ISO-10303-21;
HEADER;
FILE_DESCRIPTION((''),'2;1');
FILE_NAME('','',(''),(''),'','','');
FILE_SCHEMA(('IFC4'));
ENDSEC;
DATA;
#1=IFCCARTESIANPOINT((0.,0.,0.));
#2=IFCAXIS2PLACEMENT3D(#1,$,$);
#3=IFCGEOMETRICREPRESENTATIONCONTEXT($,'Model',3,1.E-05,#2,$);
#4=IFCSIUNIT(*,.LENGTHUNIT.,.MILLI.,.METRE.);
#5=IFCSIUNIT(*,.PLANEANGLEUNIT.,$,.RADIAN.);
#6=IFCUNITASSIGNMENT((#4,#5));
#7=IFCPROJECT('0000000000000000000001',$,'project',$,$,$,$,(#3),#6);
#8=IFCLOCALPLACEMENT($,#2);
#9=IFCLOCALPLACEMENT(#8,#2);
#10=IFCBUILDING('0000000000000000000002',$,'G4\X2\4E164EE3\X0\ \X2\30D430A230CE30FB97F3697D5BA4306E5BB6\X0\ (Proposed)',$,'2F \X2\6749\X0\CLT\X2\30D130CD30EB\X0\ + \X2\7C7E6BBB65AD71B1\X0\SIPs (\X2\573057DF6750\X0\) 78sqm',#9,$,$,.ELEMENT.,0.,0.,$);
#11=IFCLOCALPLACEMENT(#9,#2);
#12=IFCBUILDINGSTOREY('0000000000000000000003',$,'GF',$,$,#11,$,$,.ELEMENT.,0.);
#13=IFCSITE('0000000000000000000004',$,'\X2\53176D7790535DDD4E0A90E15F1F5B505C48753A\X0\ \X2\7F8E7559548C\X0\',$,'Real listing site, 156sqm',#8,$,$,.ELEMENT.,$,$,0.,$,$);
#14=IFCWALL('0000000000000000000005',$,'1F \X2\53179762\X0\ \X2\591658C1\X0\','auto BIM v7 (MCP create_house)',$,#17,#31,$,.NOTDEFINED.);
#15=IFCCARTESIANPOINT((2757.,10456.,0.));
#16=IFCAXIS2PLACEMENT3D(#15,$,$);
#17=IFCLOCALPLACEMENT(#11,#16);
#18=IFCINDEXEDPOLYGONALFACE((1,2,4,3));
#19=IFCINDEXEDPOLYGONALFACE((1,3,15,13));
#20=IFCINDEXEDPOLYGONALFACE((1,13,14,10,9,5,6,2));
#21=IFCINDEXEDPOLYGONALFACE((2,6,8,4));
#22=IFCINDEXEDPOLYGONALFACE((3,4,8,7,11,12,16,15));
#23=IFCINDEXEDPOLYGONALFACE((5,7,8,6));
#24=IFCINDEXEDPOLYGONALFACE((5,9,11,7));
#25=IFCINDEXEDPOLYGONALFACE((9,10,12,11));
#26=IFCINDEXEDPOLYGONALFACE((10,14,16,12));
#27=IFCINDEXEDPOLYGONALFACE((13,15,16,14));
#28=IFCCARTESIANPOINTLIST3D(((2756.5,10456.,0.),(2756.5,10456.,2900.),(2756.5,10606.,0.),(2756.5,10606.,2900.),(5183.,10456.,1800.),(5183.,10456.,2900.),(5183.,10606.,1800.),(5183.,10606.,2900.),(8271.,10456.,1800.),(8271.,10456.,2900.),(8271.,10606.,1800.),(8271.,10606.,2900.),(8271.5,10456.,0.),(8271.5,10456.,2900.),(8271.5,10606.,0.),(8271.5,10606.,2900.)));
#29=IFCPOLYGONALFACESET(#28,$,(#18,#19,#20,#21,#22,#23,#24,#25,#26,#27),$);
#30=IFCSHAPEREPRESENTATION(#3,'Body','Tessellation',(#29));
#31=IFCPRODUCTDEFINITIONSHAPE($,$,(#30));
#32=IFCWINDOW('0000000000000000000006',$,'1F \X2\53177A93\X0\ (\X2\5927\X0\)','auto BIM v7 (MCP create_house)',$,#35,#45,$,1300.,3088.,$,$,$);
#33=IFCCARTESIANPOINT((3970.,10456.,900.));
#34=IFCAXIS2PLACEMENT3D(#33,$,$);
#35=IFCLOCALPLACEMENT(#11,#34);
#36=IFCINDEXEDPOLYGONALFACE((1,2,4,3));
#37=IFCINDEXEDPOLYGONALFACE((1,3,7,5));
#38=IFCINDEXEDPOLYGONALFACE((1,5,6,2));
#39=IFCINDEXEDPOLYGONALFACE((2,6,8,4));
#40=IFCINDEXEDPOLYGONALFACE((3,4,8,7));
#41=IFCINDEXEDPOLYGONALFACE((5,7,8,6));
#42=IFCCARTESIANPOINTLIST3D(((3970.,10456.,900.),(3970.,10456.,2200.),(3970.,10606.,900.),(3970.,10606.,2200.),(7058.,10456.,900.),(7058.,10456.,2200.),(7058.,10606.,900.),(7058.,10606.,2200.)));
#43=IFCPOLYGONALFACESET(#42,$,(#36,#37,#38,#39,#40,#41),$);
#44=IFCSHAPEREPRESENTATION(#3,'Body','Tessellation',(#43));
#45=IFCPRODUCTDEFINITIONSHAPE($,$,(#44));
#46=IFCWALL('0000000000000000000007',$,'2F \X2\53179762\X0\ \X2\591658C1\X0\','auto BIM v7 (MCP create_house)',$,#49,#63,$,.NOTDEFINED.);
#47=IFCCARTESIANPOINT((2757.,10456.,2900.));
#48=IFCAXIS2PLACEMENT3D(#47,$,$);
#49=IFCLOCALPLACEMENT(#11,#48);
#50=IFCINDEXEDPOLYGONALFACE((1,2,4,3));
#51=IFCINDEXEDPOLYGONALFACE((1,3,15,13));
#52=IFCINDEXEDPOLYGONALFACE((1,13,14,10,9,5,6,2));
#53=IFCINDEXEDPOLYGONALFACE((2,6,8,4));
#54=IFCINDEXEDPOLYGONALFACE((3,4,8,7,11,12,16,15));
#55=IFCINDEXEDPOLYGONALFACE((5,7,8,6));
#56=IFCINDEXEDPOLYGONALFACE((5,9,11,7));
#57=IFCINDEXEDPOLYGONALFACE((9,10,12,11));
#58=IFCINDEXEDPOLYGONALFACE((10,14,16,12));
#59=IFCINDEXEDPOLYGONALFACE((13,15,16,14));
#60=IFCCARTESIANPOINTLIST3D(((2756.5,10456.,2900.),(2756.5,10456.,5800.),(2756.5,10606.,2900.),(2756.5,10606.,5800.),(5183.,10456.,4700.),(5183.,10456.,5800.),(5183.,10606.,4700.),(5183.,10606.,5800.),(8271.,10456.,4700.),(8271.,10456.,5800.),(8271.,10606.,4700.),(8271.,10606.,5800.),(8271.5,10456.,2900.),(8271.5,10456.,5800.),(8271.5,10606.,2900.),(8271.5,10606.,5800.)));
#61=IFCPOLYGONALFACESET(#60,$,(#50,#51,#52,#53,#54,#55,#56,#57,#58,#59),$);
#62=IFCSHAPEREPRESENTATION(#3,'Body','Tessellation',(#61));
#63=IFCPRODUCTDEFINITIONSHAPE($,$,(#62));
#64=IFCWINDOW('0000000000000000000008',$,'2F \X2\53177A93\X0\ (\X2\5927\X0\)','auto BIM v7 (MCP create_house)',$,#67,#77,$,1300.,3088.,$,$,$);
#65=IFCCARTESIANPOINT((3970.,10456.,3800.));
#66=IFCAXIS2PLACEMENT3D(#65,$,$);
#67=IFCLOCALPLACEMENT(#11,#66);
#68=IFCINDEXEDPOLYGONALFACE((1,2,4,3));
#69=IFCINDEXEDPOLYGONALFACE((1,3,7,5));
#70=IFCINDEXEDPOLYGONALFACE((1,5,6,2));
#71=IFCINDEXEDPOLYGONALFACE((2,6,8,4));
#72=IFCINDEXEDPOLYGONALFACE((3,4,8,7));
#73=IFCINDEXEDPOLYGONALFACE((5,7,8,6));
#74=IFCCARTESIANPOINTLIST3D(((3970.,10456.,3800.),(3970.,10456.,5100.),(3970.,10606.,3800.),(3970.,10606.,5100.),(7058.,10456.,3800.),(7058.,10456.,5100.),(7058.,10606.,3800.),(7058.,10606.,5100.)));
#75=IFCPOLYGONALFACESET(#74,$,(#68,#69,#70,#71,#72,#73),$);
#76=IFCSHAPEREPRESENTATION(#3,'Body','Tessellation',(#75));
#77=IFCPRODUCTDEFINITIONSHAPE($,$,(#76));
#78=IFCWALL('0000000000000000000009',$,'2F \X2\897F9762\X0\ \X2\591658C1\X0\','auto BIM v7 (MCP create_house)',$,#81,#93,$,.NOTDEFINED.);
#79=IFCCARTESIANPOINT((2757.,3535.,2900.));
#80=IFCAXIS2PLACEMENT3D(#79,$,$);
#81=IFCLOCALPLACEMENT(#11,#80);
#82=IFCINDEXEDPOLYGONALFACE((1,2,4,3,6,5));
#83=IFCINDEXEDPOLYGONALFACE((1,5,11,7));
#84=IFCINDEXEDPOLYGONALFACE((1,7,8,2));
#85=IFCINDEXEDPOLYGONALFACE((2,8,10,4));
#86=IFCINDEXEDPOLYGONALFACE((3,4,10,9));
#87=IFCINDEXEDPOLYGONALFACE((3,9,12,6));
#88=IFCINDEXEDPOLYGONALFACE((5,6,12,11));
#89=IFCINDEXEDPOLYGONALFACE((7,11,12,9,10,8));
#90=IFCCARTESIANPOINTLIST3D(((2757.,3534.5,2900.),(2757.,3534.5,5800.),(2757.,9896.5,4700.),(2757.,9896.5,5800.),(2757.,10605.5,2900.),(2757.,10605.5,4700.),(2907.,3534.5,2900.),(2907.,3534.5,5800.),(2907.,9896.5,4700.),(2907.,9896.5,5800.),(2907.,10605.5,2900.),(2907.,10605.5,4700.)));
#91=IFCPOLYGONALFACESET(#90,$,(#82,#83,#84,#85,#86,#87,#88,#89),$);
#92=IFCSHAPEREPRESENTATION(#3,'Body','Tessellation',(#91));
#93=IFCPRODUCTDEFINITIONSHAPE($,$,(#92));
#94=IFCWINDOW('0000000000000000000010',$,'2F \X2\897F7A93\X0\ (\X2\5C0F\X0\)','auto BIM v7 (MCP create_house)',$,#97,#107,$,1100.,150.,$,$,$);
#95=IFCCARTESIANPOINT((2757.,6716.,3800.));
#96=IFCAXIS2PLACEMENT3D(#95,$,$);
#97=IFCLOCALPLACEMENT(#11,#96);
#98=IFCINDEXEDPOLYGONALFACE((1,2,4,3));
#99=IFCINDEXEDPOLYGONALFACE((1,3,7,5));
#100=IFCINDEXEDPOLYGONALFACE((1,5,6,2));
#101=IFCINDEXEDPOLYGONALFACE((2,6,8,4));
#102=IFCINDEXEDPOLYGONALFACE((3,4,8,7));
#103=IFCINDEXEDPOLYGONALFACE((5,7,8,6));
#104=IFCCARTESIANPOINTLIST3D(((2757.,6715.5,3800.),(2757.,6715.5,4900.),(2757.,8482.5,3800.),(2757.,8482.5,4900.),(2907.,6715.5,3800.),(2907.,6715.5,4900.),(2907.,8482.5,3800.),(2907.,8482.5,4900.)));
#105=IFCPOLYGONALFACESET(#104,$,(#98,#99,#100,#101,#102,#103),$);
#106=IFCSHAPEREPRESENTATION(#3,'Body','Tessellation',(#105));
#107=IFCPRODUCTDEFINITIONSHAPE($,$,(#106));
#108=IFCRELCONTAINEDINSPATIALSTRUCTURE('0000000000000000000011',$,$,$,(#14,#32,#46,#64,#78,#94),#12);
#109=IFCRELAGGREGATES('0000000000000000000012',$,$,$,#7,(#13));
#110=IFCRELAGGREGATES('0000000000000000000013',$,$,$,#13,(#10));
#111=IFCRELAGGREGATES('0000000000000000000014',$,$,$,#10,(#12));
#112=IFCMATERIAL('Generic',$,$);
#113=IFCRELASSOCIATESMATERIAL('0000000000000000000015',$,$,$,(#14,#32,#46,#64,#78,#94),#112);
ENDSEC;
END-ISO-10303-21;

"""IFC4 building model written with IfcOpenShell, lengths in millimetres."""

from ifc_helpers import new_model, si_unit, frame, frame_2d, origin, place, context, project, spatial, rectangle, extrude, material, element, fill, save


model = new_model("IFC4")

# Units and contexts
model_context = context("Model", 3, precision=1e-05, world=origin())
ifc_project = project(units=[si_unit("LENGTHUNIT", "METRE", prefix="MILLI"), si_unit("PLANEANGLEUNIT", "RADIAN")], contexts=[model_context])

# Site, building, storey
site_placement = place(None, origin())
site = spatial("IfcSite", under=ifc_project, at=site_placement, Name="北海道川上郡弟子屈町 美留和", ObjectType="Real listing site, 156sqm", CompositionType="ELEMENT", RefElevation=0.0)
building_placement = place(site_placement, origin())
building = spatial("IfcBuilding", under=site, at=building_placement, Name="G4世代 ピアノ・音楽室の家 (Proposed)", ObjectType="2F 杉CLTパネル + 籾殻断熱SIPs (地域材) 78sqm", CompositionType="ELEMENT", ElevationOfRefHeight=0.0, ElevationOfTerrain=0.0)
storey_placement = place(building_placement, origin())
storey = spatial("IfcBuildingStorey", under=building, at=storey_placement, Name="GF", CompositionType="ELEMENT", Elevation=0.0)

# Wall, opening, window
ifc_material = material(Name="Generic")
wall_1_placement = place(storey_placement, frame((2757.0, 10456.0, 0.0)))
wall_1 = element("IfcWall", 1, at=wall_1_placement, inside=storey, material=ifc_material, Name="1F 北面 外壁", Description="auto BIM v7 (MCP create_house)", PredefinedType="NOTDEFINED", context=model_context, shape_type="SweptSolid", body=[
    extrude(rectangle(XDim=5515.0, YDim=150.0, at=frame_2d((2757.0, 75.0))), frame((2757.0, 10456.0, 0.0)), (0.0, 0.0, 1.0), 2900.0),
])
opening_1_placement = place(storey_placement, frame((3970.0, 10456.0, 900.0)))
opening_1 = element("IfcOpeningElement", 2, at=opening_1_placement, cuts=wall_1, PredefinedType="NOTDEFINED", context=model_context, shape_type="SweptSolid", body=[
    extrude(rectangle(XDim=3088.0, YDim=150.0, at=frame_2d((1544.0, 75.0))), frame((3970.0, 10456.0, 900.0)), (0.0, 0.0, 1.0), 1300.0),
])
window_1_placement = place(storey_placement, frame((3970.0, 10456.0, 900.0)))
window_1 = element("IfcWindow", 3, at=window_1_placement, inside=storey, material=ifc_material, Name="1F 北窓 (大)", Description="auto BIM v7 (MCP create_house)", OverallHeight=1300.0, OverallWidth=3088.0, context=model_context, shape_type="SweptSolid", body=[
    extrude(rectangle(XDim=3088.0, YDim=150.0, at=frame_2d((1544.0, 75.0))), frame((3970.0, 10456.0, 900.0)), (0.0, 0.0, 1.0), 1300.0),
])
fill(opening_1, window_1)

# Walls, openings, windows
wall_2_placement = place(storey_placement, frame((2757.0, 10456.0, 2900.0)))
wall_2 = element("IfcWall", 4, at=wall_2_placement, inside=storey, material=ifc_material, Name="2F 北面 外壁", Description="auto BIM v7 (MCP create_house)", PredefinedType="NOTDEFINED", context=model_context, shape_type="SweptSolid", body=[
    extrude(rectangle(XDim=5515.0, YDim=150.0, at=frame_2d((2757.0, 75.0))), frame((2757.0, 10456.0, 2900.0)), (0.0, 0.0, 1.0), 2900.0),
])
opening_2_placement = place(storey_placement, frame((3970.0, 10456.0, 3800.0)))
opening_2 = element("IfcOpeningElement", 5, at=opening_2_placement, cuts=wall_2, PredefinedType="NOTDEFINED", context=model_context, shape_type="SweptSolid", body=[
    extrude(rectangle(XDim=3088.0, YDim=150.0, at=frame_2d((1544.0, 75.0))), frame((3970.0, 10456.0, 3800.0)), (0.0, 0.0, 1.0), 1300.0),
])
window_2_placement = place(storey_placement, frame((3970.0, 10456.0, 3800.0)))
window_2 = element("IfcWindow", 6, at=window_2_placement, inside=storey, material=ifc_material, Name="2F 北窓 (大)", Description="auto BIM v7 (MCP create_house)", OverallHeight=1300.0, OverallWidth=3088.0, context=model_context, shape_type="SweptSolid", body=[
    extrude(rectangle(XDim=3088.0, YDim=150.0, at=frame_2d((1544.0, 75.0))), frame((3970.0, 10456.0, 3800.0)), (0.0, 0.0, 1.0), 1300.0),
])
fill(opening_2, window_2)
wall_3_placement = place(storey_placement, frame((2757.0, 3535.0, 2900.0)))
wall_3 = element("IfcWall", 7, at=wall_3_placement, inside=storey, material=ifc_material, Name="2F 西面 外壁", Description="auto BIM v7 (MCP create_house)", PredefinedType="NOTDEFINED", context=model_context, shape_type="SweptSolid", body=[
    extrude(rectangle(XDim=150.0, YDim=7071.0, at=frame_2d((75.0, 3535.0))), frame((2757.0, 3535.0, 2900.0)), (0.0, 0.0, 1.0), 2900.0),
])
opening_3_placement = place(storey_placement, frame((2757.0, 6716.0, 3800.0)))
opening_3 = element("IfcOpeningElement", 8, at=opening_3_placement, cuts=wall_3, PredefinedType="NOTDEFINED", context=model_context, shape_type="SweptSolid", body=[
    extrude(rectangle(XDim=150.0, YDim=1767.0, at=frame_2d((75.0, 883.0))), frame((2757.0, 6716.0, 3800.0)), (0.0, 0.0, 1.0), 1100.0),
])
window_3_placement = place(storey_placement, frame((2757.0, 6716.0, 3800.0)))
window_3 = element("IfcWindow", 9, at=window_3_placement, inside=storey, material=ifc_material, Name="2F 西窓 (小)", Description="auto BIM v7 (MCP create_house)", OverallHeight=1100.0, OverallWidth=150.0, context=model_context, shape_type="SweptSolid", body=[
    extrude(rectangle(XDim=150.0, YDim=1767.0, at=frame_2d((75.0, 883.0))), frame((2757.0, 6716.0, 3800.0)), (0.0, 0.0, 1.0), 1100.0),
])
fill(opening_3, window_3)

save(model, "model.ifc")
